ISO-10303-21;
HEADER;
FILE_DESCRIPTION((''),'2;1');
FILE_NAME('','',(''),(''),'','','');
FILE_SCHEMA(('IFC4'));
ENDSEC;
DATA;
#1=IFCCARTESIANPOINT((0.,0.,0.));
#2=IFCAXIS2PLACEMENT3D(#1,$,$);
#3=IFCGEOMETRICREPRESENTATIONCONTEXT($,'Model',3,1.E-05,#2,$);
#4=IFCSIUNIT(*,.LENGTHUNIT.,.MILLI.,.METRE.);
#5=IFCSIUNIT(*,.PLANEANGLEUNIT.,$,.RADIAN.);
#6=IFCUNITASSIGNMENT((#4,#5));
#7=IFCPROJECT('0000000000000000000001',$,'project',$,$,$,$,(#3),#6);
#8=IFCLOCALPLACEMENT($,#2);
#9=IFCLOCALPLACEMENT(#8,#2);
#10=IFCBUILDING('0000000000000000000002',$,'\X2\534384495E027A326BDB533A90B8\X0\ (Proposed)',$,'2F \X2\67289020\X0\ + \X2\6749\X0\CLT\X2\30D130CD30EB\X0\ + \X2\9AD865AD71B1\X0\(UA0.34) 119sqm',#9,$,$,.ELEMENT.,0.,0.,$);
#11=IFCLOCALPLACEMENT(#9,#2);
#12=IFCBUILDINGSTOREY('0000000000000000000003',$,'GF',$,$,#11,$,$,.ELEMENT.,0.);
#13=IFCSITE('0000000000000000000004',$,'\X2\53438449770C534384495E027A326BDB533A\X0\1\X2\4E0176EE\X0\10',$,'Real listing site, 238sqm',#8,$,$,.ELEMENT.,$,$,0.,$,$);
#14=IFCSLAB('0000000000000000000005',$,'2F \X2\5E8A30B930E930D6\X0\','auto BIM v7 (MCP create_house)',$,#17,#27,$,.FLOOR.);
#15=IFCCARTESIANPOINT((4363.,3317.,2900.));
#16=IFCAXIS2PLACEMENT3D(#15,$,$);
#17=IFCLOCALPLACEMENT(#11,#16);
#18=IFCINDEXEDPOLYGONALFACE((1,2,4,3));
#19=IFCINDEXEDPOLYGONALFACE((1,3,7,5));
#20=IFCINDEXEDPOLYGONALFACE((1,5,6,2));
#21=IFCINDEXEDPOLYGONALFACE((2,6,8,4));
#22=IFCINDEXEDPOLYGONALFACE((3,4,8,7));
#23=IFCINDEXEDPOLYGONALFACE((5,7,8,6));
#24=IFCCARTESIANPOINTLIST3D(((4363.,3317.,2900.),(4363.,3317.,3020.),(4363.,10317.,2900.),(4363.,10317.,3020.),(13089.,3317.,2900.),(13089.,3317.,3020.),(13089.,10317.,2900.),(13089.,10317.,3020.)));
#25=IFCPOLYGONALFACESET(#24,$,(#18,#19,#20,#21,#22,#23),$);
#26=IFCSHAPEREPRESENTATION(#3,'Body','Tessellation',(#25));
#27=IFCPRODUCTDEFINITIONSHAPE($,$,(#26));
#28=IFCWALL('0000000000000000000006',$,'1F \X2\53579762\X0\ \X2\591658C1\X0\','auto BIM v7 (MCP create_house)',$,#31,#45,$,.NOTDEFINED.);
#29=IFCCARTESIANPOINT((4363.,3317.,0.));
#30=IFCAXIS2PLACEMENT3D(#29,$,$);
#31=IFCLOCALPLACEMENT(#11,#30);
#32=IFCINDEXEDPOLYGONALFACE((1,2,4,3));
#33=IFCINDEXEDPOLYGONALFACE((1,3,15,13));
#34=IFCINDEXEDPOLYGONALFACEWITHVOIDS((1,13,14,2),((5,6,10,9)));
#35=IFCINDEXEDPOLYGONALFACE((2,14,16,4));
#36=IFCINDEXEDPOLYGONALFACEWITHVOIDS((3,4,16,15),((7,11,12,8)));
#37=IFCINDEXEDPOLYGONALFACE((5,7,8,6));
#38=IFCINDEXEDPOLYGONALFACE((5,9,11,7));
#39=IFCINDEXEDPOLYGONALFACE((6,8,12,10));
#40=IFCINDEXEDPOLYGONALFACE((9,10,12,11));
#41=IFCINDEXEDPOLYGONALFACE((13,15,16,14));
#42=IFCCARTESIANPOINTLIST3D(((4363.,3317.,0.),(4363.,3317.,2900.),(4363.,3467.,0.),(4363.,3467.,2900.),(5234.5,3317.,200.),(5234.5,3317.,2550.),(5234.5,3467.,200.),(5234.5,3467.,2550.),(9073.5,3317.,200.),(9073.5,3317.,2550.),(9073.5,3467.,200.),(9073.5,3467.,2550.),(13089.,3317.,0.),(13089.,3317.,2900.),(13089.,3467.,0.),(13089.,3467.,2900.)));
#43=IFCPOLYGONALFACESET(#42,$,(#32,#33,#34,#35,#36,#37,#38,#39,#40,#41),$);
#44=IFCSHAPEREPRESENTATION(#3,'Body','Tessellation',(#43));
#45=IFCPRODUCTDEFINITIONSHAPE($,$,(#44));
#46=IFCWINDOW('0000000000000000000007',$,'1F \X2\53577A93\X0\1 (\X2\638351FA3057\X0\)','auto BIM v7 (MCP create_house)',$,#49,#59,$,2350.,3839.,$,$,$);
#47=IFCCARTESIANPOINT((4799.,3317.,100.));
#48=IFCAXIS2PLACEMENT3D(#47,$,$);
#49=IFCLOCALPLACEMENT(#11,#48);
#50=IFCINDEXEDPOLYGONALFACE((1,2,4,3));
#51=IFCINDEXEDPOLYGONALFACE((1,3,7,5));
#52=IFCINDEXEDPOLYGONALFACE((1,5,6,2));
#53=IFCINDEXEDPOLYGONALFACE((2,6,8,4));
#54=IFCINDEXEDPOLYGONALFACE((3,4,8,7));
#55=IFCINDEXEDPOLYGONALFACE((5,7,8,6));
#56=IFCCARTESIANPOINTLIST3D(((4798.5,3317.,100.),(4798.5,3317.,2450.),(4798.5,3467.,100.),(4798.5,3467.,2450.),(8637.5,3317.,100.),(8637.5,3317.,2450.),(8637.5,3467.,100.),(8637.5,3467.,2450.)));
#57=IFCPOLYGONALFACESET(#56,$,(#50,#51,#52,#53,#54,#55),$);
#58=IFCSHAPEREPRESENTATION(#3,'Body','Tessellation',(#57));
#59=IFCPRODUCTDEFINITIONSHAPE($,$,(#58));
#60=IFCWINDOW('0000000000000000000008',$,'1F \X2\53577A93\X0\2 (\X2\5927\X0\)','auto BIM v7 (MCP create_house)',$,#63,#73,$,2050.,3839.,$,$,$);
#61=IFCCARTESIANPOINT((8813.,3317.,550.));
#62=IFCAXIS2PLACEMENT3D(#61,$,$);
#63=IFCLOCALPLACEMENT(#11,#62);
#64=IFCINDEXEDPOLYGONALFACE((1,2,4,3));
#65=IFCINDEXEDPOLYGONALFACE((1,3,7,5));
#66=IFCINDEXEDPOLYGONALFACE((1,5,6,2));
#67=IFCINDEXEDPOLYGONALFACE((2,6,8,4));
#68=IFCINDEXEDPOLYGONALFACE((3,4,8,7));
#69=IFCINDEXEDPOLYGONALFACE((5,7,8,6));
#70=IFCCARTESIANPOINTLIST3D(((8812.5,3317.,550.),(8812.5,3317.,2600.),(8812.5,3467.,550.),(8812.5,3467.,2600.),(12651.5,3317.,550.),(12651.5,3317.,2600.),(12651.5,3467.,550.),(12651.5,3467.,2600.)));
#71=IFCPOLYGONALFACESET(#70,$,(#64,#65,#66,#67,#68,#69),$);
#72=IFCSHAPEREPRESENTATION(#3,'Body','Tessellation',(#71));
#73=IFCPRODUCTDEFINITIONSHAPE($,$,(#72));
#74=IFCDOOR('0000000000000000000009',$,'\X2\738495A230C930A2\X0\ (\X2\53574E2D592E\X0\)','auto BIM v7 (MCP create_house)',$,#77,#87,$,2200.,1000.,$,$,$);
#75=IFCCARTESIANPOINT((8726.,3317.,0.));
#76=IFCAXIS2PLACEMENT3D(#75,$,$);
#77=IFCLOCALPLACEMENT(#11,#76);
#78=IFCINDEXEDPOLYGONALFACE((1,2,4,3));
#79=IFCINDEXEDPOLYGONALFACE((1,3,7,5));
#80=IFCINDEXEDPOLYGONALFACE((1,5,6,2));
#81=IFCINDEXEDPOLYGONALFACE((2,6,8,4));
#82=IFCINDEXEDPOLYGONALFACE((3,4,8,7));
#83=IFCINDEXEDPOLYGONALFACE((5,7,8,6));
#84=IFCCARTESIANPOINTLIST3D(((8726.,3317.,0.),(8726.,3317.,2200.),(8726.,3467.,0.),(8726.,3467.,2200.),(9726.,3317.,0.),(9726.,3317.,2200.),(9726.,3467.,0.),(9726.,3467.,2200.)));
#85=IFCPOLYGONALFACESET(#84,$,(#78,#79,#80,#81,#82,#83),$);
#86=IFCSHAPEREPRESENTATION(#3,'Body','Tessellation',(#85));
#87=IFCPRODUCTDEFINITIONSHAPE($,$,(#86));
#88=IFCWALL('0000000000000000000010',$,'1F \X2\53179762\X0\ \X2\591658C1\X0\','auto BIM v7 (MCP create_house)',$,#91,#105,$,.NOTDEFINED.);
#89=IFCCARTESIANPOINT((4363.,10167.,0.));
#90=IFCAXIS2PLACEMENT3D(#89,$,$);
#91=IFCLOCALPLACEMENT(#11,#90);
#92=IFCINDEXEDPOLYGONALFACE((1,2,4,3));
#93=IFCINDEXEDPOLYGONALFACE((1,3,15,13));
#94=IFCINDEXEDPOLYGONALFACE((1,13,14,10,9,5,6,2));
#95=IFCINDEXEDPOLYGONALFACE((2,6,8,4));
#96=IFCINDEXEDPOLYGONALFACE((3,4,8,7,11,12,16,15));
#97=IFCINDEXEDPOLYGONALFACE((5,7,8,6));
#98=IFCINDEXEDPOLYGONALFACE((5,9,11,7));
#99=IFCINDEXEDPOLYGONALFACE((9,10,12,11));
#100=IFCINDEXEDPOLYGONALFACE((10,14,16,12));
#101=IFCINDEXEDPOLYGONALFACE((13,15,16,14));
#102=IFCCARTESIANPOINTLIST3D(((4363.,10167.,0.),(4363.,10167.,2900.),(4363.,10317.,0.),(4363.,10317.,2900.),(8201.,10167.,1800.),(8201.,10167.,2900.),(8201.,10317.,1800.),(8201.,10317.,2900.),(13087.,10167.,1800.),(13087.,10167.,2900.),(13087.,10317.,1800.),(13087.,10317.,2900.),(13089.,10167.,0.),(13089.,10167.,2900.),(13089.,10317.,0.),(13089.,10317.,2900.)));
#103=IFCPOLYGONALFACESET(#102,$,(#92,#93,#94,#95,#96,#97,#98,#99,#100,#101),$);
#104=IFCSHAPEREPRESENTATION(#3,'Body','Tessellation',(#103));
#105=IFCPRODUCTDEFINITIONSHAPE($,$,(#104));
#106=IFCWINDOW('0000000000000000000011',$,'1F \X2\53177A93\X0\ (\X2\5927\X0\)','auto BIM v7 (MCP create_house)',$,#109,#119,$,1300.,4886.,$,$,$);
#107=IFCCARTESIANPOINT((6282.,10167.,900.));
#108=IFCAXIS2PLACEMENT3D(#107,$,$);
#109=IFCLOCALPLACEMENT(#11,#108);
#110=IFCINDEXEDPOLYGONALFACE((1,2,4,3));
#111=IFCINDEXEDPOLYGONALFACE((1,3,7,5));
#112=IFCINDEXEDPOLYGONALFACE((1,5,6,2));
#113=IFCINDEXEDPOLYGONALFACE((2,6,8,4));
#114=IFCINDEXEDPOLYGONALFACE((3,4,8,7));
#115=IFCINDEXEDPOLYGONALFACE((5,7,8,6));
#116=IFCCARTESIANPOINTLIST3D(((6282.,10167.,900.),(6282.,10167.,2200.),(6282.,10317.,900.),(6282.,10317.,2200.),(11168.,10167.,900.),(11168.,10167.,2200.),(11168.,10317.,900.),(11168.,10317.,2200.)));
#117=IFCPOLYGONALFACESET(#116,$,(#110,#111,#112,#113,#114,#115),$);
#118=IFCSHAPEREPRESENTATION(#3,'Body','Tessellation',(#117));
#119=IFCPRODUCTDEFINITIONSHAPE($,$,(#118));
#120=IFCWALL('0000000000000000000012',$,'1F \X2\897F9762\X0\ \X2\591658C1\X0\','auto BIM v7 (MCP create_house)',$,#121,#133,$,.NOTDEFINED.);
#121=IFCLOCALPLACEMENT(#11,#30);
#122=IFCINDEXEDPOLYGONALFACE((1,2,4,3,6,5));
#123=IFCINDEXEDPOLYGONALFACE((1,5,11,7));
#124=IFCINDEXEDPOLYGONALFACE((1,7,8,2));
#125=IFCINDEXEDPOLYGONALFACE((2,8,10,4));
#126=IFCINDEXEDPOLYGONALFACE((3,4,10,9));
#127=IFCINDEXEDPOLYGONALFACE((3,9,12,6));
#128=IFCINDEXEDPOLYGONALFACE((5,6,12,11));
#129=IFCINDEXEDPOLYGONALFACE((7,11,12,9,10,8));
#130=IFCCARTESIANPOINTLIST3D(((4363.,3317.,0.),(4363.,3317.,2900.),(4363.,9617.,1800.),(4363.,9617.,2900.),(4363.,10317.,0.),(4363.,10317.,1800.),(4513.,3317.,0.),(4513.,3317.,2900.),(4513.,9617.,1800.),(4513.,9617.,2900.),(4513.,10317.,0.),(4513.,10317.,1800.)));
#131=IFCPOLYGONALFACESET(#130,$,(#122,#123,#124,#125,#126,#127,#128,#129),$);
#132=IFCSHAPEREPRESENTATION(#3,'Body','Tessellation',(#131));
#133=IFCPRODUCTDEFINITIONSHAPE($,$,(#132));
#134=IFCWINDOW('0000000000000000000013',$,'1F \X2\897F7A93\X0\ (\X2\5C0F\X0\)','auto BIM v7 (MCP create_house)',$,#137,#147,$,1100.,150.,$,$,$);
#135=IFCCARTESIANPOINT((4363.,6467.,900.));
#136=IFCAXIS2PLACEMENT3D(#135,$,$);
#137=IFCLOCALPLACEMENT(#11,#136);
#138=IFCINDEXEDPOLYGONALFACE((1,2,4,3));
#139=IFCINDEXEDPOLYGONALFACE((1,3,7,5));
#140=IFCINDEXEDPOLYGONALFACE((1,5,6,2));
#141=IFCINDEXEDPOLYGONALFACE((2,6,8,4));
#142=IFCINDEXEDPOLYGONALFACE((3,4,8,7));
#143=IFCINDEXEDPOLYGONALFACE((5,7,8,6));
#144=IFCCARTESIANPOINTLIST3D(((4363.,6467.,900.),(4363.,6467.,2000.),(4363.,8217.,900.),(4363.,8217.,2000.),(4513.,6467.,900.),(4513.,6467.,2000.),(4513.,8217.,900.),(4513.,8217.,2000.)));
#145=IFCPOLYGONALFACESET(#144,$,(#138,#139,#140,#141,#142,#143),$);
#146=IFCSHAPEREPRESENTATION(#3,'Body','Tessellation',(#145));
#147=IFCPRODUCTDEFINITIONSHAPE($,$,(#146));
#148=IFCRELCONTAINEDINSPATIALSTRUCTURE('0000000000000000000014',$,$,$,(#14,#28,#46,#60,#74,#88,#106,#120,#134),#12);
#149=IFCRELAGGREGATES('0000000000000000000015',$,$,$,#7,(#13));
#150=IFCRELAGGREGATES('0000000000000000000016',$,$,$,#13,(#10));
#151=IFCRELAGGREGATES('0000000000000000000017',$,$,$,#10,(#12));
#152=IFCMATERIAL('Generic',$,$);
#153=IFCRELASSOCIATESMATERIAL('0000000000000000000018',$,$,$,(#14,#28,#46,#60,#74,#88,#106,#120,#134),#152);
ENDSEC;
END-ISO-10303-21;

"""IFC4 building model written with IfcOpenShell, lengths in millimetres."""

from ifc_helpers import new_model, si_unit, frame, frame_2d, origin, place, context, project, spatial, rectangle, extrude, material, element, fill, save


model = new_model("IFC4")

# Units and contexts
model_context = context("Model", 3, precision=1e-05, world=origin())
ifc_project = project(units=[si_unit("LENGTHUNIT", "METRE", prefix="MILLI"), si_unit("PLANEANGLEUNIT", "RADIAN")], contexts=[model_context])

# Site, building, storey
site_placement = place(None, origin())
site = spatial("IfcSite", under=ifc_project, at=site_placement, Name="千葉県千葉市稲毛区1丁目10", ObjectType="Real listing site, 238sqm", CompositionType="ELEMENT", RefElevation=0.0)
building_placement = place(site_placement, origin())
building = spatial("IfcBuilding", under=site, at=building_placement, Name="千葉市稲毛区邸 (Proposed)", ObjectType="2F 木造 + 杉CLTパネル + 高断熱(UA0.34) 119sqm", CompositionType="ELEMENT", ElevationOfRefHeight=0.0, ElevationOfTerrain=0.0)
storey_placement = place(building_placement, origin())
storey = spatial("IfcBuildingStorey", under=building, at=storey_placement, Name="GF", CompositionType="ELEMENT", Elevation=0.0)

# Slab
ifc_material = material(Name="Generic")
slab_1_placement = place(storey_placement, frame((4363.0, 3317.0, 2900.0)))
element("IfcSlab", 1, at=slab_1_placement, inside=storey, material=ifc_material, Name="2F 床スラブ", Description="auto BIM v7 (MCP create_house)", PredefinedType="FLOOR", context=model_context, shape_type="SweptSolid", body=[
    extrude(rectangle(XDim=8726.0, YDim=7000.0, at=frame_2d((4363.0, 3500.0))), frame((4363.0, 3317.0, 2900.0)), (0.0, 0.0, 1.0), 120.0),
])

# Wall, openings, windows, door
wall_1_placement = place(storey_placement, frame((4363.0, 3317.0, 0.0)))
wall_1 = element("IfcWall", 2, at=wall_1_placement, inside=storey, material=ifc_material, Name="1F 南面 外壁", Description="auto BIM v7 (MCP create_house)", PredefinedType="NOTDEFINED", context=model_context, shape_type="SweptSolid", body=[
    extrude(rectangle(XDim=8726.0, YDim=150.0, at=frame_2d((4363.0, 75.0))), frame((4363.0, 3317.0, 0.0)), (0.0, 0.0, 1.0), 2900.0),
])
opening_1_placement = place(storey_placement, frame((4799.0, 3317.0, 100.0)))
opening_1 = element("IfcOpeningElement", 3, at=opening_1_placement, cuts=wall_1, PredefinedType="NOTDEFINED", context=model_context, shape_type="SweptSolid", body=[
    extrude(rectangle(XDim=3839.0, YDim=150.0, at=frame_2d((1919.0, 75.0))), frame((4799.0, 3317.0, 100.0)), (0.0, 0.0, 1.0), 2350.0),
])
opening_2_placement = place(storey_placement, frame((8813.0, 3317.0, 550.0)))
opening_2 = element("IfcOpeningElement", 4, at=opening_2_placement, cuts=wall_1, PredefinedType="NOTDEFINED", context=model_context, shape_type="SweptSolid", body=[
    extrude(rectangle(XDim=3839.0, YDim=150.0, at=frame_2d((1919.0, 75.0))), frame((8813.0, 3317.0, 550.0)), (0.0, 0.0, 1.0), 2050.0),
])
opening_3_placement = place(storey_placement, frame((8726.0, 3317.0, 0.0)))
opening_3 = element("IfcOpeningElement", 5, at=opening_3_placement, cuts=wall_1, PredefinedType="NOTDEFINED", context=model_context, shape_type="SweptSolid", body=[
    extrude(rectangle(XDim=1000.0, YDim=150.0, at=frame_2d((500.0, 75.0))), frame((8726.0, 3317.0, 0.0)), (0.0, 0.0, 1.0), 2200.0),
])
window_1_placement = place(storey_placement, frame((4799.0, 3317.0, 100.0)))
window_1 = element("IfcWindow", 6, at=window_1_placement, inside=storey, material=ifc_material, Name="1F 南窓1 (掃出し)", Description="auto BIM v7 (MCP create_house)", OverallHeight=2350.0, OverallWidth=3839.0, context=model_context, shape_type="SweptSolid", body=[
    extrude(rectangle(XDim=3839.0, YDim=150.0, at=frame_2d((1919.0, 75.0))), frame((4799.0, 3317.0, 100.0)), (0.0, 0.0, 1.0), 2350.0),
])
fill(opening_1, window_1)
window_2_placement = place(storey_placement, frame((8813.0, 3317.0, 550.0)))
window_2 = element("IfcWindow", 7, at=window_2_placement, inside=storey, material=ifc_material, Name="1F 南窓2 (大)", Description="auto BIM v7 (MCP create_house)", OverallHeight=2050.0, OverallWidth=3839.0, context=model_context, shape_type="SweptSolid", body=[
    extrude(rectangle(XDim=3839.0, YDim=150.0, at=frame_2d((1919.0, 75.0))), frame((8813.0, 3317.0, 550.0)), (0.0, 0.0, 1.0), 2050.0),
])
fill(opening_2, window_2)
door_placement = place(storey_placement, frame((8726.0, 3317.0, 0.0)))
door = element("IfcDoor", 8, at=door_placement, inside=storey, material=ifc_material, Name="玄関ドア (南中央)", Description="auto BIM v7 (MCP create_house)", OverallHeight=2200.0, OverallWidth=1000.0, context=model_context, shape_type="SweptSolid", body=[
    extrude(rectangle(XDim=1000.0, YDim=150.0, at=frame_2d((500.0, 75.0))), frame((8726.0, 3317.0, 0.0)), (0.0, 0.0, 1.0), 2200.0),
])
fill(opening_3, door)

# Walls, openings, windows
wall_2_placement = place(storey_placement, frame((4363.0, 10167.0, 0.0)))
wall_2 = element("IfcWall", 9, at=wall_2_placement, inside=storey, material=ifc_material, Name="1F 北面 外壁", Description="auto BIM v7 (MCP create_house)", PredefinedType="NOTDEFINED", context=model_context, shape_type="SweptSolid", body=[
    extrude(rectangle(XDim=8726.0, YDim=150.0, at=frame_2d((4363.0, 75.0))), frame((4363.0, 10167.0, 0.0)), (0.0, 0.0, 1.0), 2900.0),
])
opening_4_placement = place(storey_placement, frame((6282.0, 10167.0, 900.0)))
opening_4 = element("IfcOpeningElement", 10, at=opening_4_placement, cuts=wall_2, PredefinedType="NOTDEFINED", context=model_context, shape_type="SweptSolid", body=[
    extrude(rectangle(XDim=4886.0, YDim=150.0, at=frame_2d((2443.0, 75.0))), frame((6282.0, 10167.0, 900.0)), (0.0, 0.0, 1.0), 1300.0),
])
window_3_placement = place(storey_placement, frame((6282.0, 10167.0, 900.0)))
window_3 = element("IfcWindow", 11, at=window_3_placement, inside=storey, material=ifc_material, Name="1F 北窓 (大)", Description="auto BIM v7 (MCP create_house)", OverallHeight=1300.0, OverallWidth=4886.0, context=model_context, shape_type="SweptSolid", body=[
    extrude(rectangle(XDim=4886.0, YDim=150.0, at=frame_2d((2443.0, 75.0))), frame((6282.0, 10167.0, 900.0)), (0.0, 0.0, 1.0), 1300.0),
])
fill(opening_4, window_3)
wall_3_placement = place(storey_placement, frame((4363.0, 3317.0, 0.0)))
wall_3 = element("IfcWall", 12, at=wall_3_placement, inside=storey, material=ifc_material, Name="1F 西面 外壁", Description="auto BIM v7 (MCP create_house)", PredefinedType="NOTDEFINED", context=model_context, shape_type="SweptSolid", body=[
    extrude(rectangle(XDim=150.0, YDim=7000.0, at=frame_2d((75.0, 3500.0))), frame((4363.0, 3317.0, 0.0)), (0.0, 0.0, 1.0), 2900.0),
])
opening_5_placement = place(storey_placement, frame((4363.0, 6467.0, 900.0)))
opening_5 = element("IfcOpeningElement", 13, at=opening_5_placement, cuts=wall_3, PredefinedType="NOTDEFINED", context=model_context, shape_type="SweptSolid", body=[
    extrude(rectangle(XDim=150.0, YDim=1750.0, at=frame_2d((75.0, 875.0))), frame((4363.0, 6467.0, 900.0)), (0.0, 0.0, 1.0), 1100.0),
])
window_4_placement = place(storey_placement, frame((4363.0, 6467.0, 900.0)))
window_4 = element("IfcWindow", 14, at=window_4_placement, inside=storey, material=ifc_material, Name="1F 西窓 (小)", Description="auto BIM v7 (MCP create_house)", OverallHeight=1100.0, OverallWidth=150.0, context=model_context, shape_type="SweptSolid", body=[
    extrude(rectangle(XDim=150.0, YDim=1750.0, at=frame_2d((75.0, 875.0))), frame((4363.0, 6467.0, 900.0)), (0.0, 0.0, 1.0), 1100.0),
])
fill(opening_5, window_4)

save(model, "model.ifc")
